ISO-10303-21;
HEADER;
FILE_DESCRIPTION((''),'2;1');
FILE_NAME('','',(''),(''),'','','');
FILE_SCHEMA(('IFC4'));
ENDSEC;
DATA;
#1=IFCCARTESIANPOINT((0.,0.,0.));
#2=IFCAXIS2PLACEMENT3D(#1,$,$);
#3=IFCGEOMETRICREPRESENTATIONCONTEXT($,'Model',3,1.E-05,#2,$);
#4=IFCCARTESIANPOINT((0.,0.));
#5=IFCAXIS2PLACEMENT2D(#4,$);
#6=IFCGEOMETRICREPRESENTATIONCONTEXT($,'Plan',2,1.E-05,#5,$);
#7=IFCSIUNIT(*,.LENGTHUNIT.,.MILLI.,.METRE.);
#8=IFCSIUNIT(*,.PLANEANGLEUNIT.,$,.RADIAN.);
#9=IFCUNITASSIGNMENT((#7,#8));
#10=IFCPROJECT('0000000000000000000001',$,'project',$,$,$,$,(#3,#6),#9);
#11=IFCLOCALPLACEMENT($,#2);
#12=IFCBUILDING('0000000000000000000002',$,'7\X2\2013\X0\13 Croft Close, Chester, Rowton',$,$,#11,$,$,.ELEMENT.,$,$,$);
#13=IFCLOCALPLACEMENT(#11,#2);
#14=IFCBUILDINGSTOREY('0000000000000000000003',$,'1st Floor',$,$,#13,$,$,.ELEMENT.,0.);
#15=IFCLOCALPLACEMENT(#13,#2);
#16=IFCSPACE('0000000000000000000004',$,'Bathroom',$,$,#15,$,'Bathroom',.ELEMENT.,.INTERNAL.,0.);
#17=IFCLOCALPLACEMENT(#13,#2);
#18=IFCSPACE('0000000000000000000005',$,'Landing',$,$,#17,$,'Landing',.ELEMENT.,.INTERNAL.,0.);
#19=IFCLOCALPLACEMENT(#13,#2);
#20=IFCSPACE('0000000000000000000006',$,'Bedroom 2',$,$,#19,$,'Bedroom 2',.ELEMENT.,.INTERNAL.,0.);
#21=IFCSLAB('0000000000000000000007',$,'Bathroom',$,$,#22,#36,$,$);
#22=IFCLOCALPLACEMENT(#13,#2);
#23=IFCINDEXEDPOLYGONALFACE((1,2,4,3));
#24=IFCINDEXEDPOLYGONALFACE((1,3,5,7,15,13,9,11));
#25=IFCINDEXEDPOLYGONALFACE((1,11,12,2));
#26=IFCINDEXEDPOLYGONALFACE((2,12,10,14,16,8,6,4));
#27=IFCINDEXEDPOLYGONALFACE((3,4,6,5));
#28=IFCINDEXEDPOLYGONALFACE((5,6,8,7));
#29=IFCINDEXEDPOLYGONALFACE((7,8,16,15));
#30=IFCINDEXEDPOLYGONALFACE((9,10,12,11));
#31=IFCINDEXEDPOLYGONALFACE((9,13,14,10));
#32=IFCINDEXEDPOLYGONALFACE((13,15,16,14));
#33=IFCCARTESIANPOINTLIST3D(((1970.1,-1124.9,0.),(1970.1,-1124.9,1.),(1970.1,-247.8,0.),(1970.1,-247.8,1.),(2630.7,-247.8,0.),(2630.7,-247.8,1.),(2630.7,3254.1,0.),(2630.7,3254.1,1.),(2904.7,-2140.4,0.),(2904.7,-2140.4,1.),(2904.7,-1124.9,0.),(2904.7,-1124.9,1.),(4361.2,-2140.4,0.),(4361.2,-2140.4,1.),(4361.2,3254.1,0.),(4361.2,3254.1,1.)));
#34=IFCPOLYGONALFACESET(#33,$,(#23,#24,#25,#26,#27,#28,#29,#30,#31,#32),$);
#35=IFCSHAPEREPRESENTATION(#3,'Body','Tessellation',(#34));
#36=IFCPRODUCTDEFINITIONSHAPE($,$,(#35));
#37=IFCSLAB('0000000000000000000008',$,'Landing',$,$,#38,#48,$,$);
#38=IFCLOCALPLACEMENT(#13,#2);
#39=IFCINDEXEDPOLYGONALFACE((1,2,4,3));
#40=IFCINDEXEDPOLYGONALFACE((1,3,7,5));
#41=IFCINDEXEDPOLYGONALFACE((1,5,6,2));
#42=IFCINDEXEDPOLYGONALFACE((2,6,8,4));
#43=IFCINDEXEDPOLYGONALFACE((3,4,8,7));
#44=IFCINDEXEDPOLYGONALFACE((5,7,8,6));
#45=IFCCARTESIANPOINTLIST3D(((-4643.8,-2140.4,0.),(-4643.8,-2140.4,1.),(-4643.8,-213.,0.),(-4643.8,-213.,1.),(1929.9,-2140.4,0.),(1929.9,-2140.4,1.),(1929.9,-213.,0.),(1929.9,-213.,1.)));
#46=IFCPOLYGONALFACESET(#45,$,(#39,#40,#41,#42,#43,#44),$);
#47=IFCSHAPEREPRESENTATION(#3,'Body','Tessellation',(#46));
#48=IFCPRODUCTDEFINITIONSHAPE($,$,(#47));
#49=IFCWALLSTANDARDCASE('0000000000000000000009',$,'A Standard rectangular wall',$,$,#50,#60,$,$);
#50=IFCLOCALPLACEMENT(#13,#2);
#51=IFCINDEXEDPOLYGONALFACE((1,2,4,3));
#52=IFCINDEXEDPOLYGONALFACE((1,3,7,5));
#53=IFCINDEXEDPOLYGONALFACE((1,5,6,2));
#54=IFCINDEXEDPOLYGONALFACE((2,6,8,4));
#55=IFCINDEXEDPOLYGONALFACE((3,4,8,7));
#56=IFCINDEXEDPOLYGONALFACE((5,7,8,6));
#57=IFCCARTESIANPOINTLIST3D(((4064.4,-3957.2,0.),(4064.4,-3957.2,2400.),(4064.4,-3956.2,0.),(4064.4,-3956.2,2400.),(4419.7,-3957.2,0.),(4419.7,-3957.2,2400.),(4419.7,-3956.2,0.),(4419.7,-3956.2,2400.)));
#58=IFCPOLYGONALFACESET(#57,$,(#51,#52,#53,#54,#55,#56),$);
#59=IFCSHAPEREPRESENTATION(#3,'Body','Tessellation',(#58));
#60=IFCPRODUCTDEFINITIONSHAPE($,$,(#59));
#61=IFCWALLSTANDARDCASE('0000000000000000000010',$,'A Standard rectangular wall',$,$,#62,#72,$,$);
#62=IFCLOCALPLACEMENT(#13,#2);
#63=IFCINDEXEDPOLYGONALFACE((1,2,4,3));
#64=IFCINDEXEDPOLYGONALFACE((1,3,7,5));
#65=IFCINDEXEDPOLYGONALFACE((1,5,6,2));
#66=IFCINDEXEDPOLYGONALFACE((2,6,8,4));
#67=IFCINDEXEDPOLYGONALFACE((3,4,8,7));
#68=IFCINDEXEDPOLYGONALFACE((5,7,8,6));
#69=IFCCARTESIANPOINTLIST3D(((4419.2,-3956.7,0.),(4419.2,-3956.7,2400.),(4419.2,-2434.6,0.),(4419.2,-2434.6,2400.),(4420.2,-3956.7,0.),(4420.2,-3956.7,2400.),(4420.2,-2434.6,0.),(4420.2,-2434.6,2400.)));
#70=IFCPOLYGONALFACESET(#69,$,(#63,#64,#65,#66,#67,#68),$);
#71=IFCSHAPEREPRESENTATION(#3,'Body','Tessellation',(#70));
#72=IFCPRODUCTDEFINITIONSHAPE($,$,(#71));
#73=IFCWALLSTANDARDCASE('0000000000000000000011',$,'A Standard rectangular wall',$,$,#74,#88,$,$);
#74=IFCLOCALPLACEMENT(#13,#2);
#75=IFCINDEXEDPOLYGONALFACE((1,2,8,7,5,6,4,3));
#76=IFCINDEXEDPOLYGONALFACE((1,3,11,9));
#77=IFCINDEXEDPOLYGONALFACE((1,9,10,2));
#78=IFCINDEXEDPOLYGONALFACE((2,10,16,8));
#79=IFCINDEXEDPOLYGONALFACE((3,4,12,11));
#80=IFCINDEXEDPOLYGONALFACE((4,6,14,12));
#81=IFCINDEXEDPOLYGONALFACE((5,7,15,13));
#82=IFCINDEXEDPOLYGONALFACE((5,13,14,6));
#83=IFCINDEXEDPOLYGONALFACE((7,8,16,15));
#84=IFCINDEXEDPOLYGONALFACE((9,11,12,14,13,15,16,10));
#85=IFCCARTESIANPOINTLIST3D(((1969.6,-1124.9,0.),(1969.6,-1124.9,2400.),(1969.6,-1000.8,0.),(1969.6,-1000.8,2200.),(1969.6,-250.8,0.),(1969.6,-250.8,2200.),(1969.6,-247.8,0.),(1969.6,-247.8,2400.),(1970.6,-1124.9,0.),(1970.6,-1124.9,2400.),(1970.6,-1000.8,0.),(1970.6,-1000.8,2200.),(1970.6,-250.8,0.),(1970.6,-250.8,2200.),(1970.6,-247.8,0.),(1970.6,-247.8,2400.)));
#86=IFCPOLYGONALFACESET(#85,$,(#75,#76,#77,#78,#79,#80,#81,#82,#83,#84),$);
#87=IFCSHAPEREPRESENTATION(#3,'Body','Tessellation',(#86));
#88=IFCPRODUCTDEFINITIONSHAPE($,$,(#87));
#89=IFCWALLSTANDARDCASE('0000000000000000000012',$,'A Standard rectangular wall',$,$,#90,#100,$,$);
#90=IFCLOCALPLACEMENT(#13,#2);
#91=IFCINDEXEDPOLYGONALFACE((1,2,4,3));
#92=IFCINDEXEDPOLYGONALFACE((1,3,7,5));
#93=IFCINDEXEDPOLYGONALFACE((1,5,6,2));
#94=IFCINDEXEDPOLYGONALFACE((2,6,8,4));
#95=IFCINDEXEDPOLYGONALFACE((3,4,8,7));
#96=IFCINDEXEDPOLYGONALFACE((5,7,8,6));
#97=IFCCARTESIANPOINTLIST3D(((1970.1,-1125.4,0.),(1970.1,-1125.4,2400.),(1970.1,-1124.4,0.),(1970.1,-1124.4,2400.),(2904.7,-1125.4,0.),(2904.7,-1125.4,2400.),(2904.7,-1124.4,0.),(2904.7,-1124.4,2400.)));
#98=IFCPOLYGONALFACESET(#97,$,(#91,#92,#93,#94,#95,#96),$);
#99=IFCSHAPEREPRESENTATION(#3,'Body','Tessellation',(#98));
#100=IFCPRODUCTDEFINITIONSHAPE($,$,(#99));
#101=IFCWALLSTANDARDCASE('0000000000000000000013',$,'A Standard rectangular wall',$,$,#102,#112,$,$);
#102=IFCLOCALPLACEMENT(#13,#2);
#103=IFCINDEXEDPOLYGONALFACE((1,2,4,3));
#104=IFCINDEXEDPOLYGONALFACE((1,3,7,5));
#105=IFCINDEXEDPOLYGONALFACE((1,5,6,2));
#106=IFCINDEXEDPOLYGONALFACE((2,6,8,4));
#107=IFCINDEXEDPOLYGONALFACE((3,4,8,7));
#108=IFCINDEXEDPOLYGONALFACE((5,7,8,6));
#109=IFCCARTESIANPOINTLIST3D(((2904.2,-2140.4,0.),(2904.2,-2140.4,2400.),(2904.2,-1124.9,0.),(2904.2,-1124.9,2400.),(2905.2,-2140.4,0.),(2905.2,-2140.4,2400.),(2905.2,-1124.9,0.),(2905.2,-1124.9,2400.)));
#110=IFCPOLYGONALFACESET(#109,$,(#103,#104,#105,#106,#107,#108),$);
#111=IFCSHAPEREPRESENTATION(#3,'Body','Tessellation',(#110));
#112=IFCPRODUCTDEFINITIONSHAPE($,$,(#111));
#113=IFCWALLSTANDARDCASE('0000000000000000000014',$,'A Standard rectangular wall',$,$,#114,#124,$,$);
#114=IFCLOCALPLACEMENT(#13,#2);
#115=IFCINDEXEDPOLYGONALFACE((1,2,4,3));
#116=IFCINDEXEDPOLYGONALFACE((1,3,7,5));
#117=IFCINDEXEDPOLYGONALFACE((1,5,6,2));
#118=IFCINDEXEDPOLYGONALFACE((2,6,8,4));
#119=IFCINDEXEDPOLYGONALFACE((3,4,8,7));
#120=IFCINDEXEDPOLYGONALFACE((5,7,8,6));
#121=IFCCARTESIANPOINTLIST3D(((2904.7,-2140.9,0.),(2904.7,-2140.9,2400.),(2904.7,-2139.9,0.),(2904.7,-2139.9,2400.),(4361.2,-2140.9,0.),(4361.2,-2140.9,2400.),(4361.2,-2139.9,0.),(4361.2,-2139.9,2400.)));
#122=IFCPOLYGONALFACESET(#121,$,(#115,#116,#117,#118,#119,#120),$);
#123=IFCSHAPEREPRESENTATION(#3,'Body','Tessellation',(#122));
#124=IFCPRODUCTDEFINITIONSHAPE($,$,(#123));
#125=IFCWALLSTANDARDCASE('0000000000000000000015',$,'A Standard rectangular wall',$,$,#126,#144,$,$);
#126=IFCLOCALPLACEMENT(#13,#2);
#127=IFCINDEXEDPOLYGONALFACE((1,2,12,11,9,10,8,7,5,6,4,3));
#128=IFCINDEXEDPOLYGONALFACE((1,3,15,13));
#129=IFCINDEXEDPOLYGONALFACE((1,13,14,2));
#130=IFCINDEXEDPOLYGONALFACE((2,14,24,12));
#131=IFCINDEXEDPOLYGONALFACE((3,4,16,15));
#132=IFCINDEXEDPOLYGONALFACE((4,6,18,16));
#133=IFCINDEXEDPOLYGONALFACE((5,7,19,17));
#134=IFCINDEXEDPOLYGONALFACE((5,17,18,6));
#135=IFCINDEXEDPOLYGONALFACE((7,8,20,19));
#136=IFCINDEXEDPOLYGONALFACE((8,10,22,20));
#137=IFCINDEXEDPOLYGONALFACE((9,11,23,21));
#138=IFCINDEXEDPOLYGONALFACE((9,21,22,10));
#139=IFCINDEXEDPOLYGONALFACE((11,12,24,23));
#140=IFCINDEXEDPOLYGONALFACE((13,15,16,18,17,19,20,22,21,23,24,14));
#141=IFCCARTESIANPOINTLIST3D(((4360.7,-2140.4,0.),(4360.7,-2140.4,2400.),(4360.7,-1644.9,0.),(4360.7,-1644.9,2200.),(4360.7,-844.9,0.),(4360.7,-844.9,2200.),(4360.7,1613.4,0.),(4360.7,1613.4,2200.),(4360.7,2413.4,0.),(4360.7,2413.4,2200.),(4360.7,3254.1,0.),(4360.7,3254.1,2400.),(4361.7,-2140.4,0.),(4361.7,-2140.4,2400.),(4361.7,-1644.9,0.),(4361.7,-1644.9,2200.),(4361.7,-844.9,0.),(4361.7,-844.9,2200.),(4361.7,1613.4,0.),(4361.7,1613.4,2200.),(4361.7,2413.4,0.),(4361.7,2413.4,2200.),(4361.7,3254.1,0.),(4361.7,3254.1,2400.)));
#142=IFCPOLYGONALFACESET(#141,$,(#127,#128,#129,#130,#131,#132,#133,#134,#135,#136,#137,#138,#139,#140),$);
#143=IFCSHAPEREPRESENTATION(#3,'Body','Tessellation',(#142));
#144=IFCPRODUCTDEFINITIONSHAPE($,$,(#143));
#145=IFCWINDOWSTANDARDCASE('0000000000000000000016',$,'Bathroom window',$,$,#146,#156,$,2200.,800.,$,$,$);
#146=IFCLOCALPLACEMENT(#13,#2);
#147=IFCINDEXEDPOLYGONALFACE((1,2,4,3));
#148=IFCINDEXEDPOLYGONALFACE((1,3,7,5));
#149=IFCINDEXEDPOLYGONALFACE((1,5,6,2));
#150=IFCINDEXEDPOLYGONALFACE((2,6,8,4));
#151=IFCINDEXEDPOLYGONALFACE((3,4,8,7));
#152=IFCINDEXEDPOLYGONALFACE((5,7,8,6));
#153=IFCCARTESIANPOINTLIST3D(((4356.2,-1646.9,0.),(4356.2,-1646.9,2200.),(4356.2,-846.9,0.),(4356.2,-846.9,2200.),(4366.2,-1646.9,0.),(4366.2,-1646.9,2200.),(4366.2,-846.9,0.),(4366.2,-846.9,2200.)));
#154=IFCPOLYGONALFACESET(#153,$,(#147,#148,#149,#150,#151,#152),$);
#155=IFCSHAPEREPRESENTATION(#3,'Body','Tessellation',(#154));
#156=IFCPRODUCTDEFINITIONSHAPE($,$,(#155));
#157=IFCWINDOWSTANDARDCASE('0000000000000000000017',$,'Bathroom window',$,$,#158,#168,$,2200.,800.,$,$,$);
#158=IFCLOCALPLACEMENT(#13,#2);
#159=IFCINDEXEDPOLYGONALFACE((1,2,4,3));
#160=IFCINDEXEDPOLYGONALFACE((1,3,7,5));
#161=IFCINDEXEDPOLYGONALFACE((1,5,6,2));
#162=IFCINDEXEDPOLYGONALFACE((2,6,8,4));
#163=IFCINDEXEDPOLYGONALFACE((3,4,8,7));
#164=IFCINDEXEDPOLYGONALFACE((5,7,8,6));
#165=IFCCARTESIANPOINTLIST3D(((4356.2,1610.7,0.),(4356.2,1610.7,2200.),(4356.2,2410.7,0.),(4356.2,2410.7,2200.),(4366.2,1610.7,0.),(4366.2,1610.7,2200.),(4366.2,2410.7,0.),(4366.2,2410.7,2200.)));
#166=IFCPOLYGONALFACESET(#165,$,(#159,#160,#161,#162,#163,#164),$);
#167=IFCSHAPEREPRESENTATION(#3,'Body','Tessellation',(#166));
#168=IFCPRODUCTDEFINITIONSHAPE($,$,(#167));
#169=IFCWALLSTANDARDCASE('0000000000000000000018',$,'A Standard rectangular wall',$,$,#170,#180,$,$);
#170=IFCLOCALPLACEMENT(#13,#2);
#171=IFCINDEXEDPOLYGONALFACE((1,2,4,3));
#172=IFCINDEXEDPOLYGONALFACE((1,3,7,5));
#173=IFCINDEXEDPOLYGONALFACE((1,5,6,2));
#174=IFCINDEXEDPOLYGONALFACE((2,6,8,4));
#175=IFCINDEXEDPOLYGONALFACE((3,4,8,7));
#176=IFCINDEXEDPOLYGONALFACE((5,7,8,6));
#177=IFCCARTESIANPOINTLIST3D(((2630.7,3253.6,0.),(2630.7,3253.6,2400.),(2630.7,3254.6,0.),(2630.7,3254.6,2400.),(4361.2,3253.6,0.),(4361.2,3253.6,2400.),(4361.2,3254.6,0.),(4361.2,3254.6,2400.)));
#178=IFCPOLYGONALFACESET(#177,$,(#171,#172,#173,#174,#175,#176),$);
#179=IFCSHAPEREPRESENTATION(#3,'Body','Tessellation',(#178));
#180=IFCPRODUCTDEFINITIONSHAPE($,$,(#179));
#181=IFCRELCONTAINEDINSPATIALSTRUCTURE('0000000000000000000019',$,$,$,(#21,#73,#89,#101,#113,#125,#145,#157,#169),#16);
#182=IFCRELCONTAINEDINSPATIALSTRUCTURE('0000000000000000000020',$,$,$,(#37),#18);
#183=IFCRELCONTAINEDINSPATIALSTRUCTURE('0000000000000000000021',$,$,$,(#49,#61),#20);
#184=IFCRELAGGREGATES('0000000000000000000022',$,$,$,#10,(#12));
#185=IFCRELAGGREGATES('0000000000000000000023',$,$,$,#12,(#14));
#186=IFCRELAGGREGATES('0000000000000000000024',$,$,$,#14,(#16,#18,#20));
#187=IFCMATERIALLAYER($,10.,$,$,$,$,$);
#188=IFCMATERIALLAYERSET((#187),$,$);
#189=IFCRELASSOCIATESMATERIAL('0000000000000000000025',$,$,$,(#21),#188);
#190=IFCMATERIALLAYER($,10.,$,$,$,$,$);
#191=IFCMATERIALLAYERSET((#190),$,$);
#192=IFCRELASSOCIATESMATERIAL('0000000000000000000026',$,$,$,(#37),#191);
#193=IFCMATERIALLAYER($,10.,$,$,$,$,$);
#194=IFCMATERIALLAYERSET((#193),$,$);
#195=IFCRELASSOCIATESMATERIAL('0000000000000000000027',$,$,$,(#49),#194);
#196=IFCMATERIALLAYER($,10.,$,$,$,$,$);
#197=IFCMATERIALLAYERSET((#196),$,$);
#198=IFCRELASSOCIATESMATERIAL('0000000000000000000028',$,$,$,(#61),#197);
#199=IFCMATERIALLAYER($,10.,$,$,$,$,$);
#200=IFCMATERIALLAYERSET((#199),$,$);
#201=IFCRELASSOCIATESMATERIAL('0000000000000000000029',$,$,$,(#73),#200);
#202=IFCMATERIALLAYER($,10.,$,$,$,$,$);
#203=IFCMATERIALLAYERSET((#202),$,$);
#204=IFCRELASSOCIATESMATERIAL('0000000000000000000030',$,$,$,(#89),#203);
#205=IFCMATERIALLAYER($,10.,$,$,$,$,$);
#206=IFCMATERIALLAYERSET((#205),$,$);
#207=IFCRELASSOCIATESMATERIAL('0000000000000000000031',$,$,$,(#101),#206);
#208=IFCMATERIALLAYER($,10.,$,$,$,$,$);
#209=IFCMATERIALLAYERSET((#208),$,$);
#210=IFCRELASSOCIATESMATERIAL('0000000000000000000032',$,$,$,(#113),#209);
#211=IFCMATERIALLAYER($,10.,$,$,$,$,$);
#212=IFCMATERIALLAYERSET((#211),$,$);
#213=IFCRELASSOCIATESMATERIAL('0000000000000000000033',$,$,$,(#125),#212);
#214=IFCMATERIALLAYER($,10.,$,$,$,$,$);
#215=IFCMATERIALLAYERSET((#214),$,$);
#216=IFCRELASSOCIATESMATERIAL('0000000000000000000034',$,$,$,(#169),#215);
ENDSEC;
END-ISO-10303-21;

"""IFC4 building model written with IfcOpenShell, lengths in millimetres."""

from ifc_helpers import new_model, si_unit, frame, origin, origin_2d, place, context, project, spatial, polyline, rectangle, outline, extrude, layer, layer_set, layer_usage, element, fill, save


model = new_model("IFC4")

# Units and contexts
model_context = context("Model", 3, precision=1e-05, world=origin())
plan_context = context("Plan", 2, precision=1e-05, world=origin_2d())
ifc_project = project(units=[si_unit("LENGTHUNIT", "METRE", prefix="MILLI"), si_unit("PLANEANGLEUNIT", "RADIAN")], contexts=[model_context, plan_context])

# Building, storey, space
building_placement = place(None, origin())
building = spatial("IfcBuilding", under=ifc_project, at=building_placement, Name="7–13 Croft Close, Chester, Rowton", CompositionType="ELEMENT")
storey_placement = place(building_placement, origin())
storey = spatial("IfcBuildingStorey", under=building, at=storey_placement, Name="1st Floor", CompositionType="ELEMENT", Elevation=0.0)
space_1_placement = place(storey_placement, origin())
space_1 = spatial("IfcSpace", under=storey, at=space_1_placement, Name="Bathroom", LongName="Bathroom", CompositionType="ELEMENT", PredefinedType="INTERNAL", ElevationWithFlooring=0.0)

# Slab
ifc_layer_1 = layer(None, 10.0)
ifc_layer_set_1 = layer_set([ifc_layer_1])
ifc_layer_usage_1 = layer_usage(ifc_layer_set_1, "AXIS2", "NEGATIVE", 150.0)
slab_1_placement = place(storey_placement, origin())
element("IfcSlab", 1, at=slab_1_placement, inside=space_1, material=ifc_layer_usage_1, Name="Bathroom", context=model_context, shape_type="SweptSolid", body=[
    extrude(outline(polyline([(2630.7, -247.8), (1970.1, -247.8), (1970.1, -1124.9), (2904.7, -1124.9), (2904.7, -2140.4), (4361.2, -2140.4), (4361.2, 3254.1), (2630.7, 3254.1), (2630.7, -247.8)])), origin(), (0.0, 0.0, 1.0), 1.0),
])

# Shared definitions
space_2_placement = place(storey_placement, origin())
space_2 = spatial("IfcSpace", under=storey, at=space_2_placement, Name="Landing", LongName="Landing", CompositionType="ELEMENT", PredefinedType="INTERNAL", ElevationWithFlooring=0.0)

# Slab
ifc_layer_2 = layer(None, 10.0)
ifc_layer_set_2 = layer_set([ifc_layer_2])
ifc_layer_usage_2 = layer_usage(ifc_layer_set_2, "AXIS2", "NEGATIVE", 150.0)
slab_2_placement = place(storey_placement, origin())
element("IfcSlab", 2, at=slab_2_placement, inside=space_2, material=ifc_layer_usage_2, Name="Landing", context=model_context, shape_type="SweptSolid", body=[
    extrude(outline(polyline([(1929.9, -213.0), (-4643.8, -213.0), (-4643.8, -2140.4), (1929.9, -2140.4), (1929.9, -213.0)])), origin(), (0.0, 0.0, 1.0), 1.0),
])

# Shared definitions
space_3_placement = place(storey_placement, origin())
space_3 = spatial("IfcSpace", under=storey, at=space_3_placement, Name="Bedroom 2", LongName="Bedroom 2", CompositionType="ELEMENT", PredefinedType="INTERNAL", ElevationWithFlooring=0.0)

# Walls
ifc_layer_3 = layer(None, 10.0)
ifc_layer_set_3 = layer_set([ifc_layer_3])
ifc_layer_usage_3 = layer_usage(ifc_layer_set_3, "AXIS2", "NEGATIVE", 150.0)
wall_1_placement = place(storey_placement, origin())
element("IfcWallStandardCase", 3, at=wall_1_placement, inside=space_3, material=ifc_layer_usage_3, Name="A Standard rectangular wall", context=model_context, shape_type="SweptSolid", body=[
    extrude(rectangle(XDim=1.0, YDim=355.3, at=origin_2d()), frame((4242.1, -3956.7, 0.0), x_axis=(0.0, 1.0, 0.0)), (0.0, 0.0, 1.0), 2400.0),
])
ifc_layer_4 = layer(None, 10.0)
ifc_layer_set_4 = layer_set([ifc_layer_4])
ifc_layer_usage_4 = layer_usage(ifc_layer_set_4, "AXIS2", "NEGATIVE", 150.0)
wall_2_placement = place(storey_placement, origin())
element("IfcWallStandardCase", 4, at=wall_2_placement, inside=space_3, material=ifc_layer_usage_4, Name="A Standard rectangular wall", context=model_context, shape_type="SweptSolid", body=[
    extrude(rectangle(XDim=1.0, YDim=1522.1, at=origin_2d()), frame((4419.7, -3195.7, 0.0), x_axis=(-1.0, 0.0, 0.0)), (0.0, 0.0, 1.0), 2400.0),
])

# Wall, opening
ifc_layer_5 = layer(None, 10.0)
ifc_layer_set_5 = layer_set([ifc_layer_5])
ifc_layer_usage_5 = layer_usage(ifc_layer_set_5, "AXIS2", "NEGATIVE", 150.0)
wall_3_placement = place(storey_placement, origin())
wall_3 = element("IfcWallStandardCase", 5, at=wall_3_placement, inside=space_1, material=ifc_layer_usage_5, Name="A Standard rectangular wall", context=model_context, shape_type="SweptSolid", body=[
    extrude(rectangle(XDim=1.0, YDim=877.1, at=origin_2d()), frame((1970.1, -686.3, 0.0), x_axis=(1.0, 0.0, 0.0)), (0.0, 0.0, 1.0), 2400.0),
])
opening_1_placement = place(storey_placement, origin())
element("IfcOpeningElement", 6, at=opening_1_placement, cuts=wall_3, context=model_context, shape_type="SweptSolid", body=[
    extrude(rectangle(XDim=10.0, YDim=750.0, at=origin_2d()), frame((1970.1, -625.8, 0.0), x_axis=(-1.0, 0.0, 0.0)), (0.0, 0.0, 1.0), 2200.0),
])

# Walls
ifc_layer_6 = layer(None, 10.0)
ifc_layer_set_6 = layer_set([ifc_layer_6])
ifc_layer_usage_6 = layer_usage(ifc_layer_set_6, "AXIS2", "NEGATIVE", 150.0)
wall_4_placement = place(storey_placement, origin())
element("IfcWallStandardCase", 7, at=wall_4_placement, inside=space_1, material=ifc_layer_usage_6, Name="A Standard rectangular wall", context=model_context, shape_type="SweptSolid", body=[
    extrude(rectangle(XDim=1.0, YDim=934.6, at=origin_2d()), frame((2437.4, -1124.9, 0.0), x_axis=(0.0, 1.0, 0.0)), (0.0, 0.0, 1.0), 2400.0),
])
ifc_layer_7 = layer(None, 10.0)
ifc_layer_set_7 = layer_set([ifc_layer_7])
ifc_layer_usage_7 = layer_usage(ifc_layer_set_7, "AXIS2", "NEGATIVE", 150.0)
wall_5_placement = place(storey_placement, origin())
element("IfcWallStandardCase", 8, at=wall_5_placement, inside=space_1, material=ifc_layer_usage_7, Name="A Standard rectangular wall", context=model_context, shape_type="SweptSolid", body=[
    extrude(rectangle(XDim=1.0, YDim=1015.5, at=origin_2d()), frame((2904.7, -1632.6, 0.0), x_axis=(1.0, 0.0, 0.0)), (0.0, 0.0, 1.0), 2400.0),
])
ifc_layer_8 = layer(None, 10.0)
ifc_layer_set_8 = layer_set([ifc_layer_8])
ifc_layer_usage_8 = layer_usage(ifc_layer_set_8, "AXIS2", "NEGATIVE", 150.0)
wall_6_placement = place(storey_placement, origin())
element("IfcWallStandardCase", 9, at=wall_6_placement, inside=space_1, material=ifc_layer_usage_8, Name="A Standard rectangular wall", context=model_context, shape_type="SweptSolid", body=[
    extrude(rectangle(XDim=1.0, YDim=1456.5, at=origin_2d()), frame((3632.9, -2140.4, 0.0), x_axis=(0.0, 1.0, 0.0)), (0.0, 0.0, 1.0), 2400.0),
])

# Wall, openings, windows
ifc_layer_9 = layer(None, 10.0)
ifc_layer_set_9 = layer_set([ifc_layer_9])
ifc_layer_usage_9 = layer_usage(ifc_layer_set_9, "AXIS2", "NEGATIVE", 150.0)
wall_7_placement = place(storey_placement, origin())
wall_7 = element("IfcWallStandardCase", 10, at=wall_7_placement, inside=space_1, material=ifc_layer_usage_9, Name="A Standard rectangular wall", context=model_context, shape_type="SweptSolid", body=[
    extrude(rectangle(XDim=1.0, YDim=5394.5, at=origin_2d()), frame((4361.2, 556.9, 0.0), x_axis=(-1.0, 0.0, 0.0)), (0.0, 0.0, 1.0), 2400.0),
])
opening_2_placement = place(storey_placement, origin())
opening_2 = element("IfcOpeningElement", 11, at=opening_2_placement, cuts=wall_7, context=model_context, shape_type="SweptSolid", body=[
    extrude(rectangle(XDim=10.0, YDim=800.0, at=origin_2d()), frame((4361.2, -1244.9, 0.0), x_axis=(-1.0, 0.0, 0.0)), (0.0, 0.0, 1.0), 2200.0),
])
opening_3_placement = place(storey_placement, origin())
opening_3 = element("IfcOpeningElement", 12, at=opening_3_placement, cuts=wall_7, context=model_context, shape_type="SweptSolid", body=[
    extrude(rectangle(XDim=10.0, YDim=800.0, at=origin_2d()), frame((4361.2, 2013.4, 0.0), x_axis=(-1.0, 0.0, 0.0)), (0.0, 0.0, 1.0), 2200.0),
])
window_1_placement = place(storey_placement, frame((0.0, -2.0, 0.0)))
window_1 = element("IfcWindowStandardCase", 13, at=window_1_placement, inside=space_1, Name="Bathroom window", OverallHeight=2200.0, OverallWidth=800.0, context=model_context, shape_type="SweptSolid", body=[
    extrude(rectangle(XDim=10.0, YDim=800.0, at=origin_2d()), frame((4361.2, -1244.9, 0.0), x_axis=(-1.0, 0.0, 0.0)), (0.0, 0.0, 1.0), 2200.0),
])
fill(opening_2, window_1)
window_2_placement = place(storey_placement, frame((0.0, -2.7, 0.0)))
window_2 = element("IfcWindowStandardCase", 14, at=window_2_placement, inside=space_1, Name="Bathroom window", OverallHeight=2200.0, OverallWidth=800.0, context=model_context, shape_type="SweptSolid", body=[
    extrude(rectangle(XDim=10.0, YDim=800.0, at=origin_2d()), frame((4361.2, 2013.4, 0.0), x_axis=(-1.0, 0.0, 0.0)), (0.0, 0.0, 1.0), 2200.0),
])
fill(opening_3, window_2)

# Wall
ifc_layer_10 = layer(None, 10.0)
ifc_layer_set_10 = layer_set([ifc_layer_10])
ifc_layer_usage_10 = layer_usage(ifc_layer_set_10, "AXIS2", "NEGATIVE", 150.0)
wall_8_placement = place(storey_placement, origin())
element("IfcWallStandardCase", 15, at=wall_8_placement, inside=space_1, material=ifc_layer_usage_10, Name="A Standard rectangular wall", context=model_context, shape_type="SweptSolid", body=[
    extrude(rectangle(XDim=1.0, YDim=1730.5, at=origin_2d()), frame((3495.9, 3254.1, 0.0), x_axis=(0.0, -1.0, 0.0)), (0.0, 0.0, 1.0), 2400.0),
])

save(model, "model.ifc")
